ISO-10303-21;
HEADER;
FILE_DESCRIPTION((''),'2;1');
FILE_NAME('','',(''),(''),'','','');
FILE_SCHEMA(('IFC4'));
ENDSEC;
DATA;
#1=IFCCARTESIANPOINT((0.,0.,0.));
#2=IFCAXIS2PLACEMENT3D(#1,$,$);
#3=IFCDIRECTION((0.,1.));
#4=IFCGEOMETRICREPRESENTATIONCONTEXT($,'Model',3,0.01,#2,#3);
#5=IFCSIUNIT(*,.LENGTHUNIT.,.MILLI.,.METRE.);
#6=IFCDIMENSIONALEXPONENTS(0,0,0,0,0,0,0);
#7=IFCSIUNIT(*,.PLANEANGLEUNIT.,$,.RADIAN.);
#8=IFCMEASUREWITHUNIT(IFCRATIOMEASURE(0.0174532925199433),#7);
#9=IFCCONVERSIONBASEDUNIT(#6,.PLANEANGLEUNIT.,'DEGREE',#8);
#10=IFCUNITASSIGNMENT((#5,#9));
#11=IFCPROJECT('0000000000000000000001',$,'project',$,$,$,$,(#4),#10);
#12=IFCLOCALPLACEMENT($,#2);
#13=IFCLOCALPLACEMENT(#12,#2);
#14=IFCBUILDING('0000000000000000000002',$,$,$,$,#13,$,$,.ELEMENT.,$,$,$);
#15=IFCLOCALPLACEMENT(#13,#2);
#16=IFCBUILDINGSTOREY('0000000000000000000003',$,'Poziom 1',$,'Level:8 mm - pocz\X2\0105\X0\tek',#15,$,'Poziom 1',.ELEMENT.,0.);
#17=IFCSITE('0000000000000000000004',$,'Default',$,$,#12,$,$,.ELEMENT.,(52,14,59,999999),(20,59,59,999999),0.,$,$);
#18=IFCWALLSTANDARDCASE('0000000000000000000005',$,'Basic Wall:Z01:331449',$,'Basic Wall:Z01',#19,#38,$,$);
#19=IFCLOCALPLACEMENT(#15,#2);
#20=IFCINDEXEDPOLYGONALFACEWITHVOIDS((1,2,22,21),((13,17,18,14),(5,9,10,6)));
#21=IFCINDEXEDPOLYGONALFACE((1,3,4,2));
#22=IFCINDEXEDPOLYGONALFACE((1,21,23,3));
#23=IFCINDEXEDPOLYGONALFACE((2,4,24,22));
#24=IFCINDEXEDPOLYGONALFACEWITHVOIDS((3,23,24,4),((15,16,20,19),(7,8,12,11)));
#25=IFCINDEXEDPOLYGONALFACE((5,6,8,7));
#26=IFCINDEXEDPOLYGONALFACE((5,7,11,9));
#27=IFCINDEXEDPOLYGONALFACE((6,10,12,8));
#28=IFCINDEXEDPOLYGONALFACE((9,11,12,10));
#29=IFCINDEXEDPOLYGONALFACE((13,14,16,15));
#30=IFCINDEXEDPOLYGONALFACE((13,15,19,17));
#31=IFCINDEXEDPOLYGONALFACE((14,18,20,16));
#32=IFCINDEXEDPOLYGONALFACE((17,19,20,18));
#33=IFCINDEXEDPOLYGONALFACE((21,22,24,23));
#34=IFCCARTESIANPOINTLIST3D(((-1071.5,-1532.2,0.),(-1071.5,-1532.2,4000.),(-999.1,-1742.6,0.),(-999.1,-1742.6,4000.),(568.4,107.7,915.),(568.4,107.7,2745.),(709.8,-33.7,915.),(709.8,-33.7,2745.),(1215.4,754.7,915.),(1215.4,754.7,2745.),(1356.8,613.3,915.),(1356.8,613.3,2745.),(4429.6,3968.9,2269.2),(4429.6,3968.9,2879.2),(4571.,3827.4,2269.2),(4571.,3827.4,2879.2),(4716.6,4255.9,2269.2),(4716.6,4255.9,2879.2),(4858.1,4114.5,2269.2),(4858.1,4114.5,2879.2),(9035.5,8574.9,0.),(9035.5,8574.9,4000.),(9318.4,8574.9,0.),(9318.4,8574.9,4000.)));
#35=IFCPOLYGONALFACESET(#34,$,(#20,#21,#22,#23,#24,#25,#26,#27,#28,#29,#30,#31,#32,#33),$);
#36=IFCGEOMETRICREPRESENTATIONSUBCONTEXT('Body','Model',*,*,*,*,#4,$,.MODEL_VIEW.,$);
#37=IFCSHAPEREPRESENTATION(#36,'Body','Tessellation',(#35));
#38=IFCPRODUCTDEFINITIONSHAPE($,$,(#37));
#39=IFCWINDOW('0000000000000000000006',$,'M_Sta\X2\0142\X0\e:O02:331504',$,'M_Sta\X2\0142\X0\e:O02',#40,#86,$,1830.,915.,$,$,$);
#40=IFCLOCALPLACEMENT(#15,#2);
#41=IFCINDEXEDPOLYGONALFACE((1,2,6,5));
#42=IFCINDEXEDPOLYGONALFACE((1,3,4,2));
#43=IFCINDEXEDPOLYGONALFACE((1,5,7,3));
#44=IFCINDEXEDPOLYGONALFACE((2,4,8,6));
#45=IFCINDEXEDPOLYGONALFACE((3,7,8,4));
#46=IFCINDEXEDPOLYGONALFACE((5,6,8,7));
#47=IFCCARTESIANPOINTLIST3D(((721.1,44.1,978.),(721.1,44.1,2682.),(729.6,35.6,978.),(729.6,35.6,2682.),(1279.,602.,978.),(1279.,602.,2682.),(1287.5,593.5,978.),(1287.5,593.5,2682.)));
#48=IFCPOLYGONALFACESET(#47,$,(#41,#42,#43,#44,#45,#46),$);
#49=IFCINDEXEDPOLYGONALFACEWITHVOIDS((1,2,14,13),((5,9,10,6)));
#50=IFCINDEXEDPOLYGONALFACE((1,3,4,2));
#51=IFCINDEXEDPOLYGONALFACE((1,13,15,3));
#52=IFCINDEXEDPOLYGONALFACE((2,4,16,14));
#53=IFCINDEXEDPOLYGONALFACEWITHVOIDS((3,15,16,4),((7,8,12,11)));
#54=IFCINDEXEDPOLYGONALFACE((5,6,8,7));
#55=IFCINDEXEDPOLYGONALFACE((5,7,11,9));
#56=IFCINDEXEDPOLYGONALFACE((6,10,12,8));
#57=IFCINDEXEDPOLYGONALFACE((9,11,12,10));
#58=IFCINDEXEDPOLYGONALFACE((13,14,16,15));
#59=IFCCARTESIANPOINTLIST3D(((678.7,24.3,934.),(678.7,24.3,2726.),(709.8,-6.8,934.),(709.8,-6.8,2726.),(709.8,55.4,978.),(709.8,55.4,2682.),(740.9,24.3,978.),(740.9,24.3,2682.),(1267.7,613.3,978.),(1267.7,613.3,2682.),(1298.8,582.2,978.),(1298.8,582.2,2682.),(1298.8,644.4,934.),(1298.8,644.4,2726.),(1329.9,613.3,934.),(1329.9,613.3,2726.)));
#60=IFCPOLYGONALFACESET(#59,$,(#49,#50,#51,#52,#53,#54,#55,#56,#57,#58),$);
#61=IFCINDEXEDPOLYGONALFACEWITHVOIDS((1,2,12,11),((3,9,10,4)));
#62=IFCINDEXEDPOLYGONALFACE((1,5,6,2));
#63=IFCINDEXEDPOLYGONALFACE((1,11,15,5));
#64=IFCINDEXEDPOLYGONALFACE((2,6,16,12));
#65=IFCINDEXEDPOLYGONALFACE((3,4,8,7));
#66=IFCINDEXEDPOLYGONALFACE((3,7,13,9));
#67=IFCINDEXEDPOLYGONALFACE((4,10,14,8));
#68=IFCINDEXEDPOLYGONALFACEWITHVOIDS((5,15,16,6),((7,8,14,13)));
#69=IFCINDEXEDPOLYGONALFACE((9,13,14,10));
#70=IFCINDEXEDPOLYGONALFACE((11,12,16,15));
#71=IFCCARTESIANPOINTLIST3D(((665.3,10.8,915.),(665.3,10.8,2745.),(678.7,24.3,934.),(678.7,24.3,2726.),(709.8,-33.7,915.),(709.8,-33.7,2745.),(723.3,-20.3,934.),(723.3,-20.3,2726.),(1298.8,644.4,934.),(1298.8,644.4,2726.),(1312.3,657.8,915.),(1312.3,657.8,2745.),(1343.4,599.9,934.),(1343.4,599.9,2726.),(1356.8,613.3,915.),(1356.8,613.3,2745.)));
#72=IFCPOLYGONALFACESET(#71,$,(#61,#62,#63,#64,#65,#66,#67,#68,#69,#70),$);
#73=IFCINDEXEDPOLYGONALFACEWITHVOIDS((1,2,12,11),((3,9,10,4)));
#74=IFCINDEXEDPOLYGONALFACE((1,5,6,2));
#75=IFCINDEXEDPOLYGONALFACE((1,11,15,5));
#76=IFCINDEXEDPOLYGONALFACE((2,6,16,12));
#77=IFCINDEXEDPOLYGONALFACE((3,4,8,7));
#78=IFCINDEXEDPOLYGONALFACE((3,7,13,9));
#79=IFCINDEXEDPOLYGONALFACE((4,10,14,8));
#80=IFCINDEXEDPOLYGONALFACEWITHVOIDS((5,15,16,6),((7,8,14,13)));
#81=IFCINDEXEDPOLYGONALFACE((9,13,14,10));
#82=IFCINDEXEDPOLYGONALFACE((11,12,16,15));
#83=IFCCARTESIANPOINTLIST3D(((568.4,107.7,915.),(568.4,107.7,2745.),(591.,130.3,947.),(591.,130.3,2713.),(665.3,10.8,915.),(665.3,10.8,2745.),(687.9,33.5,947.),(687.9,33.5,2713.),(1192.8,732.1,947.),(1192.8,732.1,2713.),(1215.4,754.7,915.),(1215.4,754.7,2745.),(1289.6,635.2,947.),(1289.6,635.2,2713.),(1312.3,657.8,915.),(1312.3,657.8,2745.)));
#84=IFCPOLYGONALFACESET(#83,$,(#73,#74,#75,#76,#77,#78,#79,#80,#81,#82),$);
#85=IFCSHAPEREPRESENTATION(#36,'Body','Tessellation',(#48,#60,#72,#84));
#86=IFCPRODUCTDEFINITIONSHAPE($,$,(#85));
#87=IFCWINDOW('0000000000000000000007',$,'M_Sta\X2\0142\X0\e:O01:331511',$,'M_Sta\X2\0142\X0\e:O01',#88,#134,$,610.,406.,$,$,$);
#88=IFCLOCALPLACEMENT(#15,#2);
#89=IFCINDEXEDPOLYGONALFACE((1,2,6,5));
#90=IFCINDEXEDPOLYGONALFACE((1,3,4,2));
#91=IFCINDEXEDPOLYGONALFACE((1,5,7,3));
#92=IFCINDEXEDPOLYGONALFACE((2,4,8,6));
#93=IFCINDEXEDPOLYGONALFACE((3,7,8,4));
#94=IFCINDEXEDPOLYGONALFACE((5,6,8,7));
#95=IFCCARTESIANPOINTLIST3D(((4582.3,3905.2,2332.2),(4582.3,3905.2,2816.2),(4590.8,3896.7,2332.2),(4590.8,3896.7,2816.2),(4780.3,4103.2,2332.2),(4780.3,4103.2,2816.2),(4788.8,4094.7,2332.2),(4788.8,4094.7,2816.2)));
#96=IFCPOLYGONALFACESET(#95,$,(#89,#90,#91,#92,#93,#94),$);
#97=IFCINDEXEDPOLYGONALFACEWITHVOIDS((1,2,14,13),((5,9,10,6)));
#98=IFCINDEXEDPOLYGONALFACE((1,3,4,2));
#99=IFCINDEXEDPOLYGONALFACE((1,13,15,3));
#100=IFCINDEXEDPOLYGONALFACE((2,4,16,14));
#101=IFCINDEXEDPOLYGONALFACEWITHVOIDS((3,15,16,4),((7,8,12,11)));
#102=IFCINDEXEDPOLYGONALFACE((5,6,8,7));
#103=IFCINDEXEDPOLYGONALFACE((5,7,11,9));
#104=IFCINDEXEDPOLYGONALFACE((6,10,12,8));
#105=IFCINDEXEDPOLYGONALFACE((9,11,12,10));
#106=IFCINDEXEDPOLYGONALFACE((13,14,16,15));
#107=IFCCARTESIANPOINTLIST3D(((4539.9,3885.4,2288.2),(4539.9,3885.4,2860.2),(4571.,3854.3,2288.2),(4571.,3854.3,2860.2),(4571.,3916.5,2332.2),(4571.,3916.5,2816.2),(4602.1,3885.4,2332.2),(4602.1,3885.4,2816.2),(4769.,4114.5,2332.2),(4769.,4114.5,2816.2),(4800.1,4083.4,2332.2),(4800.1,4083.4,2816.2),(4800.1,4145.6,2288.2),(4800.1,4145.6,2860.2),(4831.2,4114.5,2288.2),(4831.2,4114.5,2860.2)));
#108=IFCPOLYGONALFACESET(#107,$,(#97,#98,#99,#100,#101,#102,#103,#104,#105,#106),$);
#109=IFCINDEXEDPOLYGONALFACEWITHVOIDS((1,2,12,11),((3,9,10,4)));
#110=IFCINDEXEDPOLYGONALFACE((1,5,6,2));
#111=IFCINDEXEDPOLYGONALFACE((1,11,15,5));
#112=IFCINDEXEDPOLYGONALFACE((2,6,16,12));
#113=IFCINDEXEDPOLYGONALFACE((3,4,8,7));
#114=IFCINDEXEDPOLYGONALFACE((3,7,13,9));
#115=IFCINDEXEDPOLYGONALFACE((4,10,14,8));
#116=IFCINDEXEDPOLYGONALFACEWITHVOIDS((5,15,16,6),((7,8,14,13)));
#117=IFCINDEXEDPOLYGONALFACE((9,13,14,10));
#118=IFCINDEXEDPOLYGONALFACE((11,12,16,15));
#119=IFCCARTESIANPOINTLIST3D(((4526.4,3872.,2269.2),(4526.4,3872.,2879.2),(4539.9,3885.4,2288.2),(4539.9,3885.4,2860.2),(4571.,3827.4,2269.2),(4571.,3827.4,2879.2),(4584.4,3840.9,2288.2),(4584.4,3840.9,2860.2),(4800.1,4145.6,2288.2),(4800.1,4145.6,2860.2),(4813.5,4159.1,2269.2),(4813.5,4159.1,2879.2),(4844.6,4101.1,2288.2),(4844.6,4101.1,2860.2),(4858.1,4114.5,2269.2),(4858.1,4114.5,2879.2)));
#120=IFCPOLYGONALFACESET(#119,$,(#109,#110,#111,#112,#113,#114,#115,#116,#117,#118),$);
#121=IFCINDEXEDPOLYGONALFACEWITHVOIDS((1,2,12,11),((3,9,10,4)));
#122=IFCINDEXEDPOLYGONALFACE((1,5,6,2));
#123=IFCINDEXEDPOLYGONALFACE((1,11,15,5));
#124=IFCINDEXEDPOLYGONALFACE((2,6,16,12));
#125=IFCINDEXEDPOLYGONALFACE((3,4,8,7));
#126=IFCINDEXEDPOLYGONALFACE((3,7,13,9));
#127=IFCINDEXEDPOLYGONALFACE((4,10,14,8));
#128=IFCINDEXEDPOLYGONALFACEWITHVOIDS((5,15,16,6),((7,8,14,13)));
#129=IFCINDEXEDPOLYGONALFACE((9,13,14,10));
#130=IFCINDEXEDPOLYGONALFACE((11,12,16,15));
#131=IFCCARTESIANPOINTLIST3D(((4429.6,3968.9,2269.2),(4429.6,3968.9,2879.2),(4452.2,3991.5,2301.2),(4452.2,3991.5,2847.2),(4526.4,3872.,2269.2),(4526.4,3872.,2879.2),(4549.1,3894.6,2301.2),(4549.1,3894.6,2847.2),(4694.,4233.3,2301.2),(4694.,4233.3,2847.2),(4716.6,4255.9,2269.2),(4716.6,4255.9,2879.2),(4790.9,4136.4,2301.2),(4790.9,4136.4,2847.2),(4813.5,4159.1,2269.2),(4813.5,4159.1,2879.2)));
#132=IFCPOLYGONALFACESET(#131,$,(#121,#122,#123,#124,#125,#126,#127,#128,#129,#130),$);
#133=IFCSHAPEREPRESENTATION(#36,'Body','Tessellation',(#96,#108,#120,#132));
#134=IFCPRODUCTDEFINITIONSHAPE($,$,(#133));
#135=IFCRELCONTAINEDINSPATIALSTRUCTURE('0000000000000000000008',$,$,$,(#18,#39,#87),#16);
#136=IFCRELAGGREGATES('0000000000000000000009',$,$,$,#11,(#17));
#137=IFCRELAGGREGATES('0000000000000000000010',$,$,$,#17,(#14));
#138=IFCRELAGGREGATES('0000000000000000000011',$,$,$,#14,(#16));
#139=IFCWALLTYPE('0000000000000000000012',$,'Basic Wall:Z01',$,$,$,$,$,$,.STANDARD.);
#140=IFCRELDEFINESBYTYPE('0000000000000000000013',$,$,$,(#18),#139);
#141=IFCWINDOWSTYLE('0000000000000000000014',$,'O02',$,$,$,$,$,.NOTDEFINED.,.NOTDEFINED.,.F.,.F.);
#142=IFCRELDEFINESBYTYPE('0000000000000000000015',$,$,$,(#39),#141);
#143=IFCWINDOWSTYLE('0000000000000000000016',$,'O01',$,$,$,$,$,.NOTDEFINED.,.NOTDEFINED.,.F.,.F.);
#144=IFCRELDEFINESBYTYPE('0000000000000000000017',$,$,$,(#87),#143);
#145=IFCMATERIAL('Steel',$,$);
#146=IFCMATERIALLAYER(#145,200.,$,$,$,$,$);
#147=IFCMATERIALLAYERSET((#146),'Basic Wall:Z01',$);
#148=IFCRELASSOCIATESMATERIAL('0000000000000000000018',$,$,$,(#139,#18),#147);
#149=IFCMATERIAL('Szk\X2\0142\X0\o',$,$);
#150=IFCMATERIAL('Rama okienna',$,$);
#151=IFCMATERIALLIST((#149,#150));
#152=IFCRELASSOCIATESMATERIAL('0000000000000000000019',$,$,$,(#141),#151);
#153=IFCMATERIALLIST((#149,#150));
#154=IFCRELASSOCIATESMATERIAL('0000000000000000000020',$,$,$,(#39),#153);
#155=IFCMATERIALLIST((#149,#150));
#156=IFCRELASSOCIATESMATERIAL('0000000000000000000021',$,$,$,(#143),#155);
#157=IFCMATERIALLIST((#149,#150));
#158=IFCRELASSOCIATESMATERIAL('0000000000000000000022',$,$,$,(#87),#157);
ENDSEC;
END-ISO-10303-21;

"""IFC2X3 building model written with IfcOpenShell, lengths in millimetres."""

from ifc_helpers import new_model, entity, si_unit, converted_unit, direction, frame, frame_2d, origin, place, context, subcontext, project, spatial, polyline, rectangle, outline, extrude, clip, halfspace, source, transform, mapped, material, material_list, layer, layer_set, layer_usage, type_object, type_shapes, element, fill, save


model = new_model("IFC2X3")

# Units and contexts
model_context = context("Model", 3, precision=0.01, world=origin(), true_north=direction((0.0, 1.0)))
body_context = subcontext(model_context, "Body", "Model", "MODEL_VIEW")
ifc_project = project(units=[si_unit("LENGTHUNIT", "METRE", prefix="MILLI"), converted_unit("PLANEANGLEUNIT", "DEGREE", entity("IfcRatioMeasure", 0.0174532925199433), si_unit("PLANEANGLEUNIT", "RADIAN"), dimensions=[0, 0, 0, 0, 0, 0, 0])], contexts=[model_context])

# Site, building, storey
site_placement = place(None, origin())
site = spatial("IfcSite", under=ifc_project, at=site_placement, Name="Default", CompositionType="ELEMENT", RefLatitude=(52, 14, 59, 999999), RefLongitude=(20, 59, 59, 999999), RefElevation=0.0)
building_placement = place(site_placement, origin())
building = spatial("IfcBuilding", under=site, at=building_placement, CompositionType="ELEMENT")
storey_placement = place(building_placement, origin())
storey = spatial("IfcBuildingStorey", under=building, at=storey_placement, Name="Poziom 1", ObjectType="Level:8 mm - początek", LongName="Poziom 1", CompositionType="ELEMENT", Elevation=0.0)

# Shared definitions
ifc_material_1 = material(Name="Steel")
ifc_layer_1 = layer(ifc_material_1, 200.0)
ifc_layer_set_1 = layer_set([ifc_layer_1], Name="Basic Wall:Z01")
wall_type_1 = type_object("IfcWallType", Name="Basic Wall:Z01", PredefinedType="STANDARD", material=ifc_layer_set_1)

# Wall, openings, windows
ifc_layer_usage_1 = layer_usage(ifc_layer_set_1, "AXIS2", "NEGATIVE", 100.0)
wall_1_placement = place(storey_placement, frame((-1069.8, -1671.9, 0.0), z_axis=(0.0, 0.0, 1.0), x_axis=(0.707107, 0.707107, 0.0)))
wall_1 = element("IfcWallStandardCase", 1, at=wall_1_placement, inside=storey, type_object=wall_type_1, material=ifc_layer_usage_1, Name="Basic Wall:Z01:331449", ObjectType="Basic Wall:Z01", context=body_context, shape_type="Clipping", body=[
    clip(extrude(outline(polyline([(14591.1, -100.0), (14391.1, 100.0), (13684.0, 100.0), (97.5, 100.0), (0.0, -100.0), (14591.1, -100.0)])), origin(), (0.0, 0.0, 1.0), 4000.0), halfspace(origin(), True)),
])
opening_1_placement = place(wall_1_placement, frame((3331.7, 100.0, 915.0)))
opening_1 = element("IfcOpeningElement", 2, at=opening_1_placement, cuts=wall_1, ObjectType="Opening", context=body_context, shape_type="SweptSolid", body=[
    extrude(rectangle(XDim=1830.0, YDim=915.0, at=frame_2d((915.0, 457.5), x_axis=(1.0, 0.0))), frame((0.0, 0.0, 0.0), z_axis=(0.0, -1.0, 0.0), x_axis=(0.0, 0.0, 1.0)), (0.0, 0.0, 1.0), 200.0),
])
opening_2_placement = place(wall_1_placement, frame((8283.2, 100.0, 2269.2)))
opening_2 = element("IfcOpeningElement", 3, at=opening_2_placement, cuts=wall_1, ObjectType="Opening", context=body_context, shape_type="SweptSolid", body=[
    extrude(rectangle(XDim=610.0, YDim=406.0, at=frame_2d((305.0, 203.0), x_axis=(1.0, 0.0))), frame((0.0, 0.0, 0.0), z_axis=(0.0, -1.0, 0.0), x_axis=(0.0, 0.0, 1.0)), (0.0, 0.0, 1.0), 200.0),
])
ifc_material_2 = material(Name="Szkło")
ifc_material_3 = material(Name="Rama okienna")
ifc_material_list_1 = material_list([ifc_material_2, ifc_material_3])
ifc_material_list_2 = material_list([ifc_material_2, ifc_material_3])
window_style_1 = type_object("IfcWindowStyle", Name="O02", ConstructionType="NOTDEFINED", OperationType="NOTDEFINED", ParameterTakesPrecedence=False, Sizeable=False, material=ifc_material_list_2)
shared_shape_1 = source(origin(), body_context, "Body", "SweptSolid", [
    extrude(rectangle(XDim=12.0, YDim=789.0, at=frame_2d((0.0, 0.0), x_axis=(1.0, 0.0))), frame((457.5, 159.0, 63.0), z_axis=(0.0, 0.0, 1.0), x_axis=(0.0, -1.0, 0.0)), (0.0, 0.0, 1.0), 1704.0),
    extrude(outline(polyline([(-438.5, -896.0), (438.5, -896.0), (438.5, 896.0), (-438.5, 896.0), (-438.5, -896.0)]), holes=[polyline([(-394.5, -852.0), (-394.5, 852.0), (394.5, 852.0), (394.5, -852.0), (-394.5, -852.0)])]), frame((457.5, 137.0, 915.0), z_axis=(0.0, 1.0, 0.0), x_axis=(1.0, 0.0, 0.0)), (0.0, 0.0, 1.0), 44.0),
    extrude(outline(polyline([(-457.5, -915.0), (457.5, -915.0), (457.5, 915.0), (-457.5, 915.0), (-457.5, -915.0)]), holes=[polyline([(-438.5, -896.0), (-438.5, 896.0), (438.5, 896.0), (438.5, -896.0), (-438.5, -896.0)])]), frame((457.5, 137.0, 915.0), z_axis=(0.0, 1.0, 0.0), x_axis=(1.0, 0.0, 0.0)), (0.0, 0.0, 1.0), 63.0),
    extrude(outline(polyline([(-457.5, -915.0), (457.5, -915.0), (457.5, 915.0), (-457.5, 915.0), (-457.5, -915.0)]), holes=[polyline([(-425.5, -883.0), (-425.5, 883.0), (425.5, 883.0), (425.5, -883.0), (-425.5, -883.0)])]), frame((457.5, 0.0, 915.0), z_axis=(0.0, 1.0, 0.0), x_axis=(1.0, 0.0, 0.0)), (0.0, 0.0, 1.0), 137.0),
])
type_shapes(window_style_1, [shared_shape_1])
window_1_placement = place(opening_1_placement, frame((0.0, 0.0, 0.0), z_axis=(0.0, 0.0, 1.0), x_axis=(-1.0, 0.0, 0.0)))
window_1 = element("IfcWindow", 4, at=window_1_placement, inside=storey, type_object=window_style_1, material=ifc_material_list_1, Name="M_Stałe:O02:331504", ObjectType="M_Stałe:O02", OverallHeight=1830.0, OverallWidth=915.0, context=body_context, shape_type="MappedRepresentation", body=[
    mapped(shared_shape_1, transform((0.0, 0.0, 0.0), scale=1.0)),
])
fill(opening_1, window_1)
ifc_material_list_3 = material_list([ifc_material_2, ifc_material_3])
ifc_material_list_4 = material_list([ifc_material_2, ifc_material_3])
window_style_2 = type_object("IfcWindowStyle", Name="O01", ConstructionType="NOTDEFINED", OperationType="NOTDEFINED", ParameterTakesPrecedence=False, Sizeable=False, material=ifc_material_list_4)
shared_shape_2 = source(origin(), body_context, "Body", "SweptSolid", [
    extrude(rectangle(XDim=12.0, YDim=280.0, at=frame_2d((0.0, 0.0), x_axis=(1.0, 0.0))), frame((203.0, 159.0, 63.0), z_axis=(0.0, 0.0, 1.0), x_axis=(0.0, -1.0, 0.0)), (0.0, 0.0, 1.0), 484.0),
    extrude(outline(polyline([(-184.0, -286.0), (184.0, -286.0), (184.0, 286.0), (-184.0, 286.0), (-184.0, -286.0)]), holes=[polyline([(-140.0, -242.0), (-140.0, 242.0), (140.0, 242.0), (140.0, -242.0), (-140.0, -242.0)])]), frame((203.0, 137.0, 305.0), z_axis=(0.0, 1.0, 0.0), x_axis=(1.0, 0.0, 0.0)), (0.0, 0.0, 1.0), 44.0),
    extrude(outline(polyline([(-203.0, -305.0), (203.0, -305.0), (203.0, 305.0), (-203.0, 305.0), (-203.0, -305.0)]), holes=[polyline([(-184.0, -286.0), (-184.0, 286.0), (184.0, 286.0), (184.0, -286.0), (-184.0, -286.0)])]), frame((203.0, 137.0, 305.0), z_axis=(0.0, 1.0, 0.0), x_axis=(1.0, 0.0, 0.0)), (0.0, 0.0, 1.0), 63.0),
    extrude(outline(polyline([(-203.0, -305.0), (203.0, -305.0), (203.0, 305.0), (-203.0, 305.0), (-203.0, -305.0)]), holes=[polyline([(-171.0, -273.0), (-171.0, 273.0), (171.0, 273.0), (171.0, -273.0), (-171.0, -273.0)])]), frame((203.0, 0.0, 305.0), z_axis=(0.0, 1.0, 0.0), x_axis=(1.0, 0.0, 0.0)), (0.0, 0.0, 1.0), 137.0),
])
type_shapes(window_style_2, [shared_shape_2])
window_2_placement = place(opening_2_placement, frame((0.0, 0.0, 0.0), z_axis=(0.0, 0.0, 1.0), x_axis=(-1.0, 0.0, 0.0)))
window_2 = element("IfcWindow", 5, at=window_2_placement, inside=storey, type_object=window_style_2, material=ifc_material_list_3, Name="M_Stałe:O01:331511", ObjectType="M_Stałe:O01", OverallHeight=610.0, OverallWidth=406.0, context=body_context, shape_type="MappedRepresentation", body=[
    mapped(shared_shape_2, transform((0.0, 0.0, 0.0), scale=1.0)),
])
fill(opening_2, window_2)

save(model, "model.ifc")
